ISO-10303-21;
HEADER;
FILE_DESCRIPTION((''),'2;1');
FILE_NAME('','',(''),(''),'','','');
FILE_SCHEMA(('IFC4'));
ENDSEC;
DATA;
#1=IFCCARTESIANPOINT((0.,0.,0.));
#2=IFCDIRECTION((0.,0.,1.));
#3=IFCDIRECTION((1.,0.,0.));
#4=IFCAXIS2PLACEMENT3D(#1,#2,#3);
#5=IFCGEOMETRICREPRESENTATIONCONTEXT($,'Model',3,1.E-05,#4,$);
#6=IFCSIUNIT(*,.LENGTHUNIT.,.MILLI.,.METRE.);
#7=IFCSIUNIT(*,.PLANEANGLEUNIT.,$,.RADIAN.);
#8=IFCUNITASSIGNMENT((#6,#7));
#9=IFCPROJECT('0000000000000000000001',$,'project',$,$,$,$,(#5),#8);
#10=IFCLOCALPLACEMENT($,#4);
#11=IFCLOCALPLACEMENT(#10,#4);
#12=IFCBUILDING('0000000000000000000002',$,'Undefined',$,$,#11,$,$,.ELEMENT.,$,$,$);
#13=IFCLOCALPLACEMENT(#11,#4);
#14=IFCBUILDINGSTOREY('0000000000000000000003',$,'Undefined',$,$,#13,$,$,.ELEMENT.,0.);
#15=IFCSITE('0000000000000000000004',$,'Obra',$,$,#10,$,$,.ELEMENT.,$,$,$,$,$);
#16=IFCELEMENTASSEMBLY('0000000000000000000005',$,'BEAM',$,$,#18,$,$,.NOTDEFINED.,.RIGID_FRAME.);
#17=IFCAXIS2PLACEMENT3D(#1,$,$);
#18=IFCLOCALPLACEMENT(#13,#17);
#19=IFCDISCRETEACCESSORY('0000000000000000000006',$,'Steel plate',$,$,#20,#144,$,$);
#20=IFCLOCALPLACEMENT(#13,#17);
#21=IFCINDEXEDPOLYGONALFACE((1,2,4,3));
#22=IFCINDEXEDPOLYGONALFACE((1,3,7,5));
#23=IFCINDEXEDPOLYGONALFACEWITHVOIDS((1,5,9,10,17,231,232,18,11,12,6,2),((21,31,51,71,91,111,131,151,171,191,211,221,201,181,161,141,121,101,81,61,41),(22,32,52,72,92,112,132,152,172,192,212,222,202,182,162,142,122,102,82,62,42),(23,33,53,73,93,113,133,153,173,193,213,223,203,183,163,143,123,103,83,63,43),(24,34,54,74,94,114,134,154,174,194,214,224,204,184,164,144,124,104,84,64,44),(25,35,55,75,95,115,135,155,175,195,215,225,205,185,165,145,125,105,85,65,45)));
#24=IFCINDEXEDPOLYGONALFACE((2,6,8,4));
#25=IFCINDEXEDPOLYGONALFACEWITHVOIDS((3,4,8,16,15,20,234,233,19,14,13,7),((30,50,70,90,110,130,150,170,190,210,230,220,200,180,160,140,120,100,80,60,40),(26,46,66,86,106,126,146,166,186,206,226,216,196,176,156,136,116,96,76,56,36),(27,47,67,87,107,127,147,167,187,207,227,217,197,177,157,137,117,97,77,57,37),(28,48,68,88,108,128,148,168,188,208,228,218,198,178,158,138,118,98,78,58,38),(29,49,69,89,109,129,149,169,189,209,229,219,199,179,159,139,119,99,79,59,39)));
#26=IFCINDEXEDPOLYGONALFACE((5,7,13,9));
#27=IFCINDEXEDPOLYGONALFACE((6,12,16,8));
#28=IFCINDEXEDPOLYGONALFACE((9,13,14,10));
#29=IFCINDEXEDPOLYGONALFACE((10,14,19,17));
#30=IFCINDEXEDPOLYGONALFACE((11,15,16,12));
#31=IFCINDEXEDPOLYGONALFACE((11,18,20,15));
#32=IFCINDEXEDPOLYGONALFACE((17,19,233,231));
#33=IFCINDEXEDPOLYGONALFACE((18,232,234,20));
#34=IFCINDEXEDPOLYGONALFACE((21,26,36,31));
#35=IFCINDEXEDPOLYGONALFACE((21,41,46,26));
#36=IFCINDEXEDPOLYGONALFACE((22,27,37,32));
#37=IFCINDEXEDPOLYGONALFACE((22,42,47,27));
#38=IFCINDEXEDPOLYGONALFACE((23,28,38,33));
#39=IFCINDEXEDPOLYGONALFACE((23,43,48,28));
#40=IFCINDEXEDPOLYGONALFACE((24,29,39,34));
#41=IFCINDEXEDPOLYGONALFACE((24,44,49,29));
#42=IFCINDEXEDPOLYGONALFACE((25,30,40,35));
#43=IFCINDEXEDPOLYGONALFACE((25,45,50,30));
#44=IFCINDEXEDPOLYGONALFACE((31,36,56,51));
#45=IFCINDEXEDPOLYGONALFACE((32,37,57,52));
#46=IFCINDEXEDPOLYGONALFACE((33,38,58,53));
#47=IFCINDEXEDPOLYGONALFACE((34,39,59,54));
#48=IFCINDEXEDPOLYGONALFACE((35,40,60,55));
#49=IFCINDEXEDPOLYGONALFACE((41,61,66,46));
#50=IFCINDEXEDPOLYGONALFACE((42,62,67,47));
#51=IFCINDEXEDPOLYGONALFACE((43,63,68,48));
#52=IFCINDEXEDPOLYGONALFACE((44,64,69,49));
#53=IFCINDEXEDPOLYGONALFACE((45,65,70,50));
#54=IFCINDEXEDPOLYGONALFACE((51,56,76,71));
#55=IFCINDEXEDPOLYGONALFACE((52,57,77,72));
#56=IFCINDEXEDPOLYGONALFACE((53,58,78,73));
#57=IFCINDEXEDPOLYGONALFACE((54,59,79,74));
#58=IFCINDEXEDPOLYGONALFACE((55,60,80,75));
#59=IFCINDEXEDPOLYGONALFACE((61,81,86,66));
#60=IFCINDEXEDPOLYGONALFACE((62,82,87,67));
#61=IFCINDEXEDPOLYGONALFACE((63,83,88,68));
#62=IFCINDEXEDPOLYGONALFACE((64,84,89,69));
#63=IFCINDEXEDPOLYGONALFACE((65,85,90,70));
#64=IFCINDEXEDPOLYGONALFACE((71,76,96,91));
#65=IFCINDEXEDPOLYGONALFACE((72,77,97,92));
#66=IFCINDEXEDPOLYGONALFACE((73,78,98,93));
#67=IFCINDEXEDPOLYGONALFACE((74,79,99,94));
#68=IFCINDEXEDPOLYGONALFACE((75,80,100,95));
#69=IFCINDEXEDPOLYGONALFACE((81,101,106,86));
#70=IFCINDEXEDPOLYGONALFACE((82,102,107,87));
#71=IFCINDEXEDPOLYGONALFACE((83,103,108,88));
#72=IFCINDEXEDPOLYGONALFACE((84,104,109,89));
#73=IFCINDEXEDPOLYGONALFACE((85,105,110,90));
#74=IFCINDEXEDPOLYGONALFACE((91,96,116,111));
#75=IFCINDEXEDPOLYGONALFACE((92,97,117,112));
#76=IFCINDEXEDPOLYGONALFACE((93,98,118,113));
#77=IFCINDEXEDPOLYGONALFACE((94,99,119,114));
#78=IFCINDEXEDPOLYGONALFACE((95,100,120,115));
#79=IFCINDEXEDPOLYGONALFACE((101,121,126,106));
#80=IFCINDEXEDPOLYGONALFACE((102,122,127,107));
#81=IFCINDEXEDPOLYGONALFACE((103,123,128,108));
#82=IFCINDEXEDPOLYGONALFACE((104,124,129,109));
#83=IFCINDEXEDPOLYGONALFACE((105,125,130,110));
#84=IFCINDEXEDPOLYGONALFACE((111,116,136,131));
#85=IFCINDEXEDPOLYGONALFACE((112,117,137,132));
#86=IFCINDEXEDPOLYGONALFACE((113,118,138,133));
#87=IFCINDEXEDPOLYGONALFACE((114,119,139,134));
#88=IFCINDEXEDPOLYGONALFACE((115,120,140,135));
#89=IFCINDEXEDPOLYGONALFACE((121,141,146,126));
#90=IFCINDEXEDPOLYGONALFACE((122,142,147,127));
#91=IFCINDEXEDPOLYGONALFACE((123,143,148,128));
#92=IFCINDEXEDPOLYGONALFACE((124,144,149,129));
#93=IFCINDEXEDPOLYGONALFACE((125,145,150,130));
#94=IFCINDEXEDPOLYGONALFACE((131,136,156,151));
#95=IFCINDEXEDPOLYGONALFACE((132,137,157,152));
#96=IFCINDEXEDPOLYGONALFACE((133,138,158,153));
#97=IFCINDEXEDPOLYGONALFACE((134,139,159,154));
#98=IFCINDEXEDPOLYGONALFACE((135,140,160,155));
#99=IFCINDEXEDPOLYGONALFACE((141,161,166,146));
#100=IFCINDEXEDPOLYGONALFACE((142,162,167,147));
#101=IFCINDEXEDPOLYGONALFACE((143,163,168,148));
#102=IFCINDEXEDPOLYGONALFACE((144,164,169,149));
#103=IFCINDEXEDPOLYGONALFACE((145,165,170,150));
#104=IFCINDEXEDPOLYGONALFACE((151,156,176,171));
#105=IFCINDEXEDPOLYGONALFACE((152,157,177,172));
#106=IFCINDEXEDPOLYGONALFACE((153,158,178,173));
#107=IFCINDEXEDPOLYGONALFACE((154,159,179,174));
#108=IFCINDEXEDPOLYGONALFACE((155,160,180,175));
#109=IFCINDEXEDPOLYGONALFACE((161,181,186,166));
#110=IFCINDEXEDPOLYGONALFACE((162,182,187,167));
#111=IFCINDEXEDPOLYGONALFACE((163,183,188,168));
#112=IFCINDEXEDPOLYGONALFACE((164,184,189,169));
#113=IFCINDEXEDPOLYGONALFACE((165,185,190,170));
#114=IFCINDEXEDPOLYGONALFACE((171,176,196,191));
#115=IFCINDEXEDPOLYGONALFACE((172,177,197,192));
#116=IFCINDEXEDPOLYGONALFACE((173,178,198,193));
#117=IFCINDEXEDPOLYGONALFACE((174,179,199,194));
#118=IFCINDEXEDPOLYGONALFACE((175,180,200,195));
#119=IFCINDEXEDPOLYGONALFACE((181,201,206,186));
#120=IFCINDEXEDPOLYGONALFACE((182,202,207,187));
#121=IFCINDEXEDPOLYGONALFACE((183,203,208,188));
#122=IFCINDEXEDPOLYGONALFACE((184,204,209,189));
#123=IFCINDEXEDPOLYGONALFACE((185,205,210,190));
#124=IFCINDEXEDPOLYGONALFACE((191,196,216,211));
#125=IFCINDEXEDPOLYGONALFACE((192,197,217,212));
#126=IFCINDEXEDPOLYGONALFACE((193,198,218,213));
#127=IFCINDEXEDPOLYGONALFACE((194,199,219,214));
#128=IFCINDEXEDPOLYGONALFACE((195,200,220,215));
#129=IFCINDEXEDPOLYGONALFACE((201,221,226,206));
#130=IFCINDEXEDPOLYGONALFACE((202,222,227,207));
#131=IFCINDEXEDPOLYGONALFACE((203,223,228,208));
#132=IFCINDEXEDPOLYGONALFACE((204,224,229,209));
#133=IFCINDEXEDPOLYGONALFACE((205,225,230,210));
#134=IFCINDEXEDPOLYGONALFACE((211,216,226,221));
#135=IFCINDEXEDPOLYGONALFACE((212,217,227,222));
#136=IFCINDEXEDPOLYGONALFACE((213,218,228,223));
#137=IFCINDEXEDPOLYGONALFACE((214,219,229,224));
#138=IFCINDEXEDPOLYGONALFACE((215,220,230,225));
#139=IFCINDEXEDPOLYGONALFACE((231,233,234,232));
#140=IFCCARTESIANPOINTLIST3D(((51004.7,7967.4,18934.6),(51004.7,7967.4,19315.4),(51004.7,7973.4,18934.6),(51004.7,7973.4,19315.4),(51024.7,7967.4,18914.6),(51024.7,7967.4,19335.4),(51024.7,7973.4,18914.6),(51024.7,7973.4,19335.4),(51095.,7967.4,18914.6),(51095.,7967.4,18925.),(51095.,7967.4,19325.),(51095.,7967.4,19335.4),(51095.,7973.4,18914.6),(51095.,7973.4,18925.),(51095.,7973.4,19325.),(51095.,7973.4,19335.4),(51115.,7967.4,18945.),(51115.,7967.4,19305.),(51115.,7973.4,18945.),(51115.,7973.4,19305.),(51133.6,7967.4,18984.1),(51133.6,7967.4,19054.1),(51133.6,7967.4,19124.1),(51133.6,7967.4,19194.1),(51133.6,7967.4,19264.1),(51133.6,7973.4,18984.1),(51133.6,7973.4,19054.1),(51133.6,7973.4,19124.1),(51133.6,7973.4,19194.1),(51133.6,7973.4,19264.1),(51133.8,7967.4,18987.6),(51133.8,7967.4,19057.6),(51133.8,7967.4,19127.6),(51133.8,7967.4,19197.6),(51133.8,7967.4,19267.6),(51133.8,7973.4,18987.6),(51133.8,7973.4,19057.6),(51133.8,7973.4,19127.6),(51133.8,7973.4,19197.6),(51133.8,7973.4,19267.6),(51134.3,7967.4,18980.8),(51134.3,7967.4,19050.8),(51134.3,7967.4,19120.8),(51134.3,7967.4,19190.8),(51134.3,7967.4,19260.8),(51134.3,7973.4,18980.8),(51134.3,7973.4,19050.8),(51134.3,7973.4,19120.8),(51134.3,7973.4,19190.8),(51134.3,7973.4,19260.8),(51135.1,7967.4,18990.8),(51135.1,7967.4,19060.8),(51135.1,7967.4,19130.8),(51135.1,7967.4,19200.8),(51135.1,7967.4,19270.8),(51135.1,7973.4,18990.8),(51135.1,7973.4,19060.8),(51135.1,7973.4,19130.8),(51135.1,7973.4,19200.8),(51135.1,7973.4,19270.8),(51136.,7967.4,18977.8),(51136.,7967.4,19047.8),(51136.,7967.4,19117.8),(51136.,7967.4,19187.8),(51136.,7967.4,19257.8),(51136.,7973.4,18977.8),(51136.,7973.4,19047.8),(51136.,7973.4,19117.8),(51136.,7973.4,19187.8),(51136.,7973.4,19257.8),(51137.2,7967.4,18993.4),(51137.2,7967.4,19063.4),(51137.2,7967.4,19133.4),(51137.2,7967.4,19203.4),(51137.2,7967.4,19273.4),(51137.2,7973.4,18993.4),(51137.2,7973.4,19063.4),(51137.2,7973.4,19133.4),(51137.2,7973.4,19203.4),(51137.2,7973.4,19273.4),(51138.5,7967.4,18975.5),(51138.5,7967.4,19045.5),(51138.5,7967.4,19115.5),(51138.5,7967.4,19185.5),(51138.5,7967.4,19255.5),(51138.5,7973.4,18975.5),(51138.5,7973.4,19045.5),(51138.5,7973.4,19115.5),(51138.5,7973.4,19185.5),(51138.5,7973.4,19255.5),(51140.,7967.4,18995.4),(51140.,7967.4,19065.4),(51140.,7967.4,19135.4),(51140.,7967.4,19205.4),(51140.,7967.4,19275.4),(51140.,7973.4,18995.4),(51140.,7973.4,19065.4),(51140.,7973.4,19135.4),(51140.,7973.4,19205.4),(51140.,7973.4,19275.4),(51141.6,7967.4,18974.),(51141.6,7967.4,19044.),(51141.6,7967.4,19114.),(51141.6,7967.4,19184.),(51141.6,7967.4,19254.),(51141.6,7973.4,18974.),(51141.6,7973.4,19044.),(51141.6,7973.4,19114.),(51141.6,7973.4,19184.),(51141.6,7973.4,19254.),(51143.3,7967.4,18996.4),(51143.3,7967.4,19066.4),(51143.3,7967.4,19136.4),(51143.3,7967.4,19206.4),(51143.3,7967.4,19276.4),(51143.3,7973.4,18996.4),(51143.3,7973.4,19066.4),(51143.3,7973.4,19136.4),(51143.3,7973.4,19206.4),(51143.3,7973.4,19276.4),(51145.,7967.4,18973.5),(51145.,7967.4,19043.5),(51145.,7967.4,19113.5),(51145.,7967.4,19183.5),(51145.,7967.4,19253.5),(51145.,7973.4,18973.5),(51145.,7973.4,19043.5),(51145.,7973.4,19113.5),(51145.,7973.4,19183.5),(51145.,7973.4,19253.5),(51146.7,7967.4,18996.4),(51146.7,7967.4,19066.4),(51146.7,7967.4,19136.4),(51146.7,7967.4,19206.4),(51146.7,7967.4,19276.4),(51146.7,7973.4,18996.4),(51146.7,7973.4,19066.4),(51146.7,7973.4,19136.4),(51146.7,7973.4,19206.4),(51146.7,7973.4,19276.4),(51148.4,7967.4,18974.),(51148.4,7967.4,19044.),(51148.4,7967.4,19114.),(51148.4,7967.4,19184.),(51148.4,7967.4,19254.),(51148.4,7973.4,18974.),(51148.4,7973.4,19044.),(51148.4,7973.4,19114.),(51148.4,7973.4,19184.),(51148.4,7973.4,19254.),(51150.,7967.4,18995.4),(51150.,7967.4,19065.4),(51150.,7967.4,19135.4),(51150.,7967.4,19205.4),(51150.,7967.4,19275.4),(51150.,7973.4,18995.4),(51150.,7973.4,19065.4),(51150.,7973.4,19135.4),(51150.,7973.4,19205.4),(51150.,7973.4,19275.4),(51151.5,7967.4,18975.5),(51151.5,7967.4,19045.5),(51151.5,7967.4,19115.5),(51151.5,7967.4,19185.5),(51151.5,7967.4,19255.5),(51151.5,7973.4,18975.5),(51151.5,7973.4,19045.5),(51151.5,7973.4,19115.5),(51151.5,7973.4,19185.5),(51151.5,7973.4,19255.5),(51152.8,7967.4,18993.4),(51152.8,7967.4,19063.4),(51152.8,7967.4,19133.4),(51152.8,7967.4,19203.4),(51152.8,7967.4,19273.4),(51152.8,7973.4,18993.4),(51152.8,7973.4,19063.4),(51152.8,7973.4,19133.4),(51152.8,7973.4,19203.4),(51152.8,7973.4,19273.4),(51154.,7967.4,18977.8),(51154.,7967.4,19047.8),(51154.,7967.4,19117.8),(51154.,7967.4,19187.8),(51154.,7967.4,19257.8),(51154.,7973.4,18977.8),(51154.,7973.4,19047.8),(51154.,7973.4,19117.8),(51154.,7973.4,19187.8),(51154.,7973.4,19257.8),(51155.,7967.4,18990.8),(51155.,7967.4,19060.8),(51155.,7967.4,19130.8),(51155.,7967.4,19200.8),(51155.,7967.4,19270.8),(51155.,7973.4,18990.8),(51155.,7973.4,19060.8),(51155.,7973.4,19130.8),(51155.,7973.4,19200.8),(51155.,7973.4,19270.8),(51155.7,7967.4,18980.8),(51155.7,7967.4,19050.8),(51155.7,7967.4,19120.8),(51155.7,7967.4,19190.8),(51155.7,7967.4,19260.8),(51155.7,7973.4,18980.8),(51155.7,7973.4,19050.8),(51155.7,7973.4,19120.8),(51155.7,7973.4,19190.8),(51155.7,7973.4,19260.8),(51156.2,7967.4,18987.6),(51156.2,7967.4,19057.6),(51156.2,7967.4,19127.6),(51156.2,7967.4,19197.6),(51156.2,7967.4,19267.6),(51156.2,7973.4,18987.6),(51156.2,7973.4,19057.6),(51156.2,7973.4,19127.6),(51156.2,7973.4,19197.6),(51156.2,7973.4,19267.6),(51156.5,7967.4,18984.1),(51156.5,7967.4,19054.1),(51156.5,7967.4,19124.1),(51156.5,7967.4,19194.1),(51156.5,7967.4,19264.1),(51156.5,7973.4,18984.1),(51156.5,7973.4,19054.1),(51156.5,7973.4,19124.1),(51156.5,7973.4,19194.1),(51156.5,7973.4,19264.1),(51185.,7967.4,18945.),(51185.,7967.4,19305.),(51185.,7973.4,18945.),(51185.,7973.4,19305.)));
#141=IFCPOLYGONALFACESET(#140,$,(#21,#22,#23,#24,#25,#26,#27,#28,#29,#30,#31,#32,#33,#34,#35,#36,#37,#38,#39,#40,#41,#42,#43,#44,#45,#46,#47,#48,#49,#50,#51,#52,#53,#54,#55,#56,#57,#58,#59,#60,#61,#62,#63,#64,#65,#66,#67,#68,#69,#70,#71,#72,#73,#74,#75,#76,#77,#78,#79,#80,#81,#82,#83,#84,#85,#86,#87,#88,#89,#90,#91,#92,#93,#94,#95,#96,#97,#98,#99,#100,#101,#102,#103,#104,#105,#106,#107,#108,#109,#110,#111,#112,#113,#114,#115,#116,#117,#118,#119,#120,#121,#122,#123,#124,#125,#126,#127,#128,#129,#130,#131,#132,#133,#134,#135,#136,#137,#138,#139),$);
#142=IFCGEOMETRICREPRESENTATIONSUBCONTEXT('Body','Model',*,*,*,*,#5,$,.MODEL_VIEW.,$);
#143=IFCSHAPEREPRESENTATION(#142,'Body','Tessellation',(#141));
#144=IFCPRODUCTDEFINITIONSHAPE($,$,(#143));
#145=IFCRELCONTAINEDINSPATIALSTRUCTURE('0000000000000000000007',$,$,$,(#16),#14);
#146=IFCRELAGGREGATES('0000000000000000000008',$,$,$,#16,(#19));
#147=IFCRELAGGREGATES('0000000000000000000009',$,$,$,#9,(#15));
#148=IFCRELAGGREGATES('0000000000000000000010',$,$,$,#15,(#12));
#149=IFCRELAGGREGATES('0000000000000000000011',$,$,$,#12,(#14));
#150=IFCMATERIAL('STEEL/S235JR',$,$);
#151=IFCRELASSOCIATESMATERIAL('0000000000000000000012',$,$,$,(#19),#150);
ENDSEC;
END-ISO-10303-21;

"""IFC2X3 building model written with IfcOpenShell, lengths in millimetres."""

from ifc_helpers import new_model, si_unit, frame, origin_with_axes, origin_2d_with_axis, place, context, subcontext, project, spatial, polyline, circle, outline, extrude, source, transform, mapped, material, element, aggregate, save


model = new_model("IFC2X3")

# Units and contexts
model_context = context("Model", 3, precision=1e-05, world=origin_with_axes())
body_context = subcontext(model_context, "Body", "Model", "MODEL_VIEW")
ifc_project = project(units=[si_unit("LENGTHUNIT", "METRE", prefix="MILLI"), si_unit("PLANEANGLEUNIT", "RADIAN")], contexts=[model_context])

# Site, building, storey
site_placement = place(None, origin_with_axes())
site = spatial("IfcSite", under=ifc_project, at=site_placement, Name="Obra", CompositionType="ELEMENT")
building_placement = place(site_placement, origin_with_axes())
building = spatial("IfcBuilding", under=site, at=building_placement, Name="Undefined", CompositionType="ELEMENT")
storey_placement = place(building_placement, origin_with_axes())
storey = spatial("IfcBuildingStorey", under=building, at=storey_placement, Name="Undefined", CompositionType="ELEMENT", Elevation=0.0)

# Shared definitions
ifc_material_1 = material(Name="STEEL/S235JR")

# Element assembly
assembly_1_placement = place(storey_placement, origin_with_axes())
assembly_1 = element("IfcElementAssembly", 1, at=assembly_1_placement, inside=storey, Name="BEAM", AssemblyPlace="NOTDEFINED", PredefinedType="RIGID_FRAME")

# Discrete accessory, opening
discrete_accessory_1_placement = place(assembly_1_placement, frame((51004.7, 7970.4, 18934.6), z_axis=(-0.000183, -1.0, 0.0), x_axis=(0.707107, -0.00013, -0.707107)))
discrete_accessory_1 = element("IfcDiscreteAccessory", 2, at=discrete_accessory_1_placement, material=ifc_material_1, Name="Steel plate", context=body_context, shape_type="SweptSolid", body=[
    extrude(outline(polyline([(0.0, 0.0), (28.3, 0.0), (78.0, 49.7), (70.6, 57.1), (70.6, 85.3), (120.1, 134.8), (-134.4, 389.4), (-183.9, 339.9), (-212.2, 339.9), (-219.6, 347.3), (-269.3, 297.6), (-269.3, 269.3), (0.0, 0.0)])), frame((0.0, 0.0, -3.0), z_axis=(0.0, 0.0, 1.0), x_axis=(1.0, 0.0, 0.0)), (0.0, 0.0, 1.0), 6.0),
])
shared_shape_1 = source(origin_with_axes(), body_context, "Body", "SweptSolid", [
    extrude(circle(Radius=11.5, at=origin_2d_with_axis()), frame((0.0, 4.6, 0.0), z_axis=(0.0, 1.0, 0.0), x_axis=(1.0, 0.0, 0.0)), (0.0, 0.0, 1.0), 6.2),
])
opening_1_placement = place(assembly_1_placement, frame((51105.0, 7962.6, 19305.0), z_axis=(1.0, -0.000183, 0.0), x_axis=(0.0, 0.0, -1.0)))
element("IfcOpeningElement", 3, at=opening_1_placement, cuts=discrete_accessory_1, ObjectType="Opening", context=body_context, shape_type="MappedRepresentation", body=[
    mapped(shared_shape_1, transform((40.0, 0.0, 40.0))),
    mapped(shared_shape_1, transform((110.0, 0.0, 40.0))),
    mapped(shared_shape_1, transform((180.0, 0.0, 40.0))),
    mapped(shared_shape_1, transform((250.0, 0.0, 40.0))),
    mapped(shared_shape_1, transform((320.0, 0.0, 40.0))),
])
aggregate(assembly_1, [discrete_accessory_1])

save(model, "model.ifc")
